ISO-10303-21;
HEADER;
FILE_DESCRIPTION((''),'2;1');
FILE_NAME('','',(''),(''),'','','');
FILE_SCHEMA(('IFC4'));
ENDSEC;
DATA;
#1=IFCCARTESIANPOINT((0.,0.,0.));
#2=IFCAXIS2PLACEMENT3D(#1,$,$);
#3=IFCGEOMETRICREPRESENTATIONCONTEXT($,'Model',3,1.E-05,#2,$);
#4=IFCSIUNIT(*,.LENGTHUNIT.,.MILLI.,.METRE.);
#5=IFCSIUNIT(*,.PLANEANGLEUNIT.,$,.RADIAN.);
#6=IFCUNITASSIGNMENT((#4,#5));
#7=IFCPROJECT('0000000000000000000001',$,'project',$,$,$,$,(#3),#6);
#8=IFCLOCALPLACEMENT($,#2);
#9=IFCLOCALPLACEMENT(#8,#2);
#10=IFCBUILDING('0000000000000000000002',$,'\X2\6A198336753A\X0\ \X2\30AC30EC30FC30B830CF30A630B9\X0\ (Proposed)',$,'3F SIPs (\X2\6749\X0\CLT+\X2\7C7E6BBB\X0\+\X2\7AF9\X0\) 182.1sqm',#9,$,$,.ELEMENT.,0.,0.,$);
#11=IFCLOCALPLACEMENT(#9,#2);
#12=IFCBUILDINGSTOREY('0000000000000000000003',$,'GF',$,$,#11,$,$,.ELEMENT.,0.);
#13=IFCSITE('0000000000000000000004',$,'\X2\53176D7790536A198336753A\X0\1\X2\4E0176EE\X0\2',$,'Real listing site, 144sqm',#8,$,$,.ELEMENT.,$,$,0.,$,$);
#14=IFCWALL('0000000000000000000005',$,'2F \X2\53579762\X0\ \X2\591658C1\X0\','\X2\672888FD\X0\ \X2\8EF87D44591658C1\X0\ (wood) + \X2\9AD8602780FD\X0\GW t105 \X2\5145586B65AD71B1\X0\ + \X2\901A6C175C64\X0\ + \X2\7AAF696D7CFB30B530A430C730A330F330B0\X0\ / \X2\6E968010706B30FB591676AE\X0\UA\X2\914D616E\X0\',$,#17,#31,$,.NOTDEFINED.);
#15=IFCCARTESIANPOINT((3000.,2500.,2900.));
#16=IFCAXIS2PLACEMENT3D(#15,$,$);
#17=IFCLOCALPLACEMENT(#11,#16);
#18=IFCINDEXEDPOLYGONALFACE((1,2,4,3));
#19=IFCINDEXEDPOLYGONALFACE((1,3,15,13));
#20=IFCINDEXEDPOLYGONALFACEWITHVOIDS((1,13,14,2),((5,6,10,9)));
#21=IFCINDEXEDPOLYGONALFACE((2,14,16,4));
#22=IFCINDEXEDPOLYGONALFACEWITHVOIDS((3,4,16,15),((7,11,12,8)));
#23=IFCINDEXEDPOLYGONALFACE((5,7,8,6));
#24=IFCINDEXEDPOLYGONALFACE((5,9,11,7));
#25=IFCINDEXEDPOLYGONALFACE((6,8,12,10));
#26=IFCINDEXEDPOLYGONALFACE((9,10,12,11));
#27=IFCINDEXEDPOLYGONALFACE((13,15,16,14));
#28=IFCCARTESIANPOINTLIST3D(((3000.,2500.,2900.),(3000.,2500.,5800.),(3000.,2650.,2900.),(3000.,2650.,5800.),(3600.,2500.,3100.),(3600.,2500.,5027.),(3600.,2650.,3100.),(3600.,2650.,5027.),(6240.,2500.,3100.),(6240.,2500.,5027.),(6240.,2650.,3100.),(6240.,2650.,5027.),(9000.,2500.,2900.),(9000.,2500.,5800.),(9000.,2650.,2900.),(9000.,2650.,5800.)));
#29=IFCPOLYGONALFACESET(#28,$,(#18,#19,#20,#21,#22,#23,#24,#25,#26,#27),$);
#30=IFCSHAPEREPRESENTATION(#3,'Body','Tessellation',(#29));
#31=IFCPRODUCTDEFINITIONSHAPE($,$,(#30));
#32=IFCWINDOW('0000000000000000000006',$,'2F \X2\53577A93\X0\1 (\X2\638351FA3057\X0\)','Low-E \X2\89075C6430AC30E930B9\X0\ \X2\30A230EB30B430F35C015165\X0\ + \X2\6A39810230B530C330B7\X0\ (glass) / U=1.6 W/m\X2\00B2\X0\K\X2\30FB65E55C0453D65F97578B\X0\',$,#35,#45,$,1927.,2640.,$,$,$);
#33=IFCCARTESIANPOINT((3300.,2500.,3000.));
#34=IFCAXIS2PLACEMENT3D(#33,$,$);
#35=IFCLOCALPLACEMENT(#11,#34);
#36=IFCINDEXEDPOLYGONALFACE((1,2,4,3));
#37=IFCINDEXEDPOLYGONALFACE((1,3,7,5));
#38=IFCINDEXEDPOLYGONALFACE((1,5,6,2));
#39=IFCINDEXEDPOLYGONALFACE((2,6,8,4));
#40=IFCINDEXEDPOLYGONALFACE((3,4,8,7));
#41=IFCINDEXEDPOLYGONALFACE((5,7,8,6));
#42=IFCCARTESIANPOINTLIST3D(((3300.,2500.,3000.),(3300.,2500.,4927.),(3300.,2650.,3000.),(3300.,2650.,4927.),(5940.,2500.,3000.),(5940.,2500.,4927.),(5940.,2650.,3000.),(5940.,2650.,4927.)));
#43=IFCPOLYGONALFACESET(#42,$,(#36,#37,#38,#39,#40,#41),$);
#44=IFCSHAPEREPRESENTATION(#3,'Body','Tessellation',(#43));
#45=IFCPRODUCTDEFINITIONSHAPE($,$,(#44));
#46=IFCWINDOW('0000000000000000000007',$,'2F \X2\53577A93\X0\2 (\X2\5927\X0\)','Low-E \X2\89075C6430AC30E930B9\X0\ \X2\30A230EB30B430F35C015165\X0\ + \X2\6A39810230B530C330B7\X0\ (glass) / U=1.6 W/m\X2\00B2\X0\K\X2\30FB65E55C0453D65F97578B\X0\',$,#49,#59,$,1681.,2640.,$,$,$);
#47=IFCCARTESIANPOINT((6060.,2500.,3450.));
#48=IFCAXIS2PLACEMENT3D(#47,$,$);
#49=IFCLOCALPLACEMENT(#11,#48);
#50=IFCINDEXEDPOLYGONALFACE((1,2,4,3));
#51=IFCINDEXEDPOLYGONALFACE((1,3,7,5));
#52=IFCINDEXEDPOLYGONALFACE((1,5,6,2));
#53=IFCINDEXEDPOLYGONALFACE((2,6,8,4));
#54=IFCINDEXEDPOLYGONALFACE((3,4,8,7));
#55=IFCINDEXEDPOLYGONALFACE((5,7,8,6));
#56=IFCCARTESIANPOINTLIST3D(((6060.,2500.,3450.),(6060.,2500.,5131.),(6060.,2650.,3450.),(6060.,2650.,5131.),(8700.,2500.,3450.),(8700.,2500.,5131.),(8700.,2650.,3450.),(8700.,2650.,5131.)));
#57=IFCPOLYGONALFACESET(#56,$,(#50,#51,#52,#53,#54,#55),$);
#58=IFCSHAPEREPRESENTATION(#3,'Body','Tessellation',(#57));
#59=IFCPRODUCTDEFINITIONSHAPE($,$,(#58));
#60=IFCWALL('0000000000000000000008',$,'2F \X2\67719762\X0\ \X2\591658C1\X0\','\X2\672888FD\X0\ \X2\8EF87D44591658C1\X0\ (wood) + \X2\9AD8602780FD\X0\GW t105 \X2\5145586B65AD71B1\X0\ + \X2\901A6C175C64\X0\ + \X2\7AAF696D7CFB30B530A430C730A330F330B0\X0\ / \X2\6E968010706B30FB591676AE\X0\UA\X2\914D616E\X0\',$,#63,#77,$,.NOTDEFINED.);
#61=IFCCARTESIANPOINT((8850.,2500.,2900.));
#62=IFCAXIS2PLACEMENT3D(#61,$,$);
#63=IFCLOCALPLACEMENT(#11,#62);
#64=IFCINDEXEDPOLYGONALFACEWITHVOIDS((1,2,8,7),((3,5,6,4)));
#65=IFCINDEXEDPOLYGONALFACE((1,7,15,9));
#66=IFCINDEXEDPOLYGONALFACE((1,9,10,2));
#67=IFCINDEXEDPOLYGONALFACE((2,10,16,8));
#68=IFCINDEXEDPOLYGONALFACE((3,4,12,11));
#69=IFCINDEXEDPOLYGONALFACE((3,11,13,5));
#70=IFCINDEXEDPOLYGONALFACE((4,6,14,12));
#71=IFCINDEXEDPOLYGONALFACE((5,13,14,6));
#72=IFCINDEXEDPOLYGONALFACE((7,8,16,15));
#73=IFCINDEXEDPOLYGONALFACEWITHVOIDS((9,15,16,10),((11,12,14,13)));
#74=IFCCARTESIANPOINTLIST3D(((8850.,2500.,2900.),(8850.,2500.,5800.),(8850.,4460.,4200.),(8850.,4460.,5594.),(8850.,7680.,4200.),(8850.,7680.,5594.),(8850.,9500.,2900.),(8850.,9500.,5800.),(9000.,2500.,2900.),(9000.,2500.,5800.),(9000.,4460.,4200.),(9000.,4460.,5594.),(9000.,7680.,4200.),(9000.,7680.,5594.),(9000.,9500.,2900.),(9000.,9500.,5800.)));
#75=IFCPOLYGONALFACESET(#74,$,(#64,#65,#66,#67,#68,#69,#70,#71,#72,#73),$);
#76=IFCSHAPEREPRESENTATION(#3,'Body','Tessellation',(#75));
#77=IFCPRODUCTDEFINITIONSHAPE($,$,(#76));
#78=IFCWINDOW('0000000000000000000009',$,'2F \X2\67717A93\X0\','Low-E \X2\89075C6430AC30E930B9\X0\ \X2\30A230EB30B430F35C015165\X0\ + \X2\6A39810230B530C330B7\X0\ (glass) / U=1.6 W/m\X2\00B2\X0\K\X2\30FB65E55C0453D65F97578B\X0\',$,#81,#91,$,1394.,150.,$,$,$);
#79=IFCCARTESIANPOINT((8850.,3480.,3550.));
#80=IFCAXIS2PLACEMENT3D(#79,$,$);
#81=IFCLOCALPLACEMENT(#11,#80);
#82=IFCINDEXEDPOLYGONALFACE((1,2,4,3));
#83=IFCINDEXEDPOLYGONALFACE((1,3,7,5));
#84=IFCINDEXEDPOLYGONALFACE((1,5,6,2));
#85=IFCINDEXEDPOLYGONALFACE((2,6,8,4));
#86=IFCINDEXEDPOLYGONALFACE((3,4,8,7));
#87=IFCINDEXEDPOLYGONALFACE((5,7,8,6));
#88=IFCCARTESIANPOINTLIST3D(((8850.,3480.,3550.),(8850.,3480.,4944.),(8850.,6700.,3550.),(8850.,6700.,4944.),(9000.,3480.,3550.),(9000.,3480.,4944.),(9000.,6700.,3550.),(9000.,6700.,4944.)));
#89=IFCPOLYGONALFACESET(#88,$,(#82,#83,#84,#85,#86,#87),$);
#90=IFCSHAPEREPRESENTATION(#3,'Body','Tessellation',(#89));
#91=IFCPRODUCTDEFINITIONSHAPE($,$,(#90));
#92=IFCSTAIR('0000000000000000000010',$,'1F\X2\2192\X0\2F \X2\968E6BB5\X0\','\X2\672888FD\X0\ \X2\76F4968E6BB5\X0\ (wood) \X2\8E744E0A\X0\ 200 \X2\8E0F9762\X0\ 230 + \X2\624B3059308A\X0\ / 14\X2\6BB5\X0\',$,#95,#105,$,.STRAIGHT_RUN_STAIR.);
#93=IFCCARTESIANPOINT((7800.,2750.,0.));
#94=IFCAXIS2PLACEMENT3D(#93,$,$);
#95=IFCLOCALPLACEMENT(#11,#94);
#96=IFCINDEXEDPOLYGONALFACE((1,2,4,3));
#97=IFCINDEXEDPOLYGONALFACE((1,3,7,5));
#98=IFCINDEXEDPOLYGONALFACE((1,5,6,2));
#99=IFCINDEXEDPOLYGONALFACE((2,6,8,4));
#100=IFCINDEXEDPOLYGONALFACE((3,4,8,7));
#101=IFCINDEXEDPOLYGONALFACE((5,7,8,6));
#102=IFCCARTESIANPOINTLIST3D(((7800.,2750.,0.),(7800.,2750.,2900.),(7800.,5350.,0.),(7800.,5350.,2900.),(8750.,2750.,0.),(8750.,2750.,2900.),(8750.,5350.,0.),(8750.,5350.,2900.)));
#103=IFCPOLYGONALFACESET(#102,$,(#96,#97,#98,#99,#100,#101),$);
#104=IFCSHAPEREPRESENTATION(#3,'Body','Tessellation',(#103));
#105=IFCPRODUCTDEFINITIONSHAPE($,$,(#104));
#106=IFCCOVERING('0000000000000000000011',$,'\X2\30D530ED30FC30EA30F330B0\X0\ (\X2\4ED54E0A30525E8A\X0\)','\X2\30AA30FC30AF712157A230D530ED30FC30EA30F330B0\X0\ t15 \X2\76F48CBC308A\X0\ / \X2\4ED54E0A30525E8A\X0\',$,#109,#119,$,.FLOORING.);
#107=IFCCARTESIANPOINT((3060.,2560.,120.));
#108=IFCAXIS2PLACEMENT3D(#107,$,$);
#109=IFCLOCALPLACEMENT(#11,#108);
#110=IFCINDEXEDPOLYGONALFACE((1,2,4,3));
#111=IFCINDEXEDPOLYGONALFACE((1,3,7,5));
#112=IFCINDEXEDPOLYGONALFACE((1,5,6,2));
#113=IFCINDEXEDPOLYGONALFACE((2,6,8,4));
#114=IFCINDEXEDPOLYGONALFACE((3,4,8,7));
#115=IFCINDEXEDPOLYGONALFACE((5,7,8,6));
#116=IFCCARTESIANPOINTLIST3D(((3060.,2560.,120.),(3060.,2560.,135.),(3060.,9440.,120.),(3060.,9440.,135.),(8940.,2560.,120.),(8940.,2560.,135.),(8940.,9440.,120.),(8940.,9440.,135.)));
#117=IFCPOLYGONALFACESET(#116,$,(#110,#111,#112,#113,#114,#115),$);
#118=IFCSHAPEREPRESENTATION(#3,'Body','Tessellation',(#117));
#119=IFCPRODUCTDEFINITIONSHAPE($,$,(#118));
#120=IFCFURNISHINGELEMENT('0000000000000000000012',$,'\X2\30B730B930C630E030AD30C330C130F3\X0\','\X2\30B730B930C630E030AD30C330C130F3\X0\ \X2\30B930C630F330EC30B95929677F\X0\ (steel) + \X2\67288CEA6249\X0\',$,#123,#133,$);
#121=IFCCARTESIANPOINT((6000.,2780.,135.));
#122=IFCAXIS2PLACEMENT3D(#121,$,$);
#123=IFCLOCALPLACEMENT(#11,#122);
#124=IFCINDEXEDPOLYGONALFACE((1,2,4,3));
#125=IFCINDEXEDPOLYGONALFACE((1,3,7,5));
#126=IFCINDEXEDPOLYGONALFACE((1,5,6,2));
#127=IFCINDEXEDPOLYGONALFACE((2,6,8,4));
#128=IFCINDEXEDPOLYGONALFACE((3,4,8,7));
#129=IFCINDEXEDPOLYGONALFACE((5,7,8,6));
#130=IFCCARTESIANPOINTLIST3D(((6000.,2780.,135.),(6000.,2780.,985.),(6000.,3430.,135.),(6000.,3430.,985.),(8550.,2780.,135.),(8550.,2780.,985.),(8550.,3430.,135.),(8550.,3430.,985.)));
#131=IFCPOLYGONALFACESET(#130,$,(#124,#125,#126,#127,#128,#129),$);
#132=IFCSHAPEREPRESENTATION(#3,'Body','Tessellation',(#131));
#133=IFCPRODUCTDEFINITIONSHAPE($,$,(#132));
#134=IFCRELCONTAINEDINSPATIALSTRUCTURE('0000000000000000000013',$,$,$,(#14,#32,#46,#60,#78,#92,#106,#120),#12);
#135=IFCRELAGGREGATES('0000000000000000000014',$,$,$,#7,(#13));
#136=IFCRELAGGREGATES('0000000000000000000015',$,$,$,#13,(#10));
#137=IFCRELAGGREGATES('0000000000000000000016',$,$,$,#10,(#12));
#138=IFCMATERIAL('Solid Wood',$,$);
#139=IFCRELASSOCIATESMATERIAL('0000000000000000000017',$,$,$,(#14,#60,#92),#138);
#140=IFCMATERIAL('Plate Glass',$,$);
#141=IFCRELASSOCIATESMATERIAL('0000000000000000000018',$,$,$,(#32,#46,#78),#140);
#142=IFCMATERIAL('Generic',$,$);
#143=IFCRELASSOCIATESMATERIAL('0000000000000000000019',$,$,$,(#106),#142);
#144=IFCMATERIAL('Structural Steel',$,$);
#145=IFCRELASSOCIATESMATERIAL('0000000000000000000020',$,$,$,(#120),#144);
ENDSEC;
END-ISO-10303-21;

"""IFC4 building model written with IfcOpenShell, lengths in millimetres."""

from ifc_helpers import new_model, si_unit, frame, frame_2d, origin, place, context, project, spatial, rectangle, extrude, material, element, fill, save


model = new_model("IFC4")

# Units and contexts
model_context = context("Model", 3, precision=1e-05, world=origin())
ifc_project = project(units=[si_unit("LENGTHUNIT", "METRE", prefix="MILLI"), si_unit("PLANEANGLEUNIT", "RADIAN")], contexts=[model_context])

# Site, building, storey
site_placement = place(None, origin())
site = spatial("IfcSite", under=ifc_project, at=site_placement, Name="北海道標茶町1丁目2", ObjectType="Real listing site, 144sqm", CompositionType="ELEMENT", RefElevation=0.0)
building_placement = place(site_placement, origin())
building = spatial("IfcBuilding", under=site, at=building_placement, Name="標茶町 ガレージハウス (Proposed)", ObjectType="3F SIPs (杉CLT+籾殻+竹) 182.1sqm", CompositionType="ELEMENT", ElevationOfRefHeight=0.0, ElevationOfTerrain=0.0)
storey_placement = place(building_placement, origin())
storey = spatial("IfcBuildingStorey", under=building, at=storey_placement, Name="GF", CompositionType="ELEMENT", Elevation=0.0)

# Shared definitions
ifc_material_1 = material(Name="Solid Wood")

# Shared definitions
ifc_material_2 = material(Name="Plate Glass")

# Wall, openings, windows
wall_1_placement = place(storey_placement, frame((3000.0, 2500.0, 2900.0)))
wall_1 = element("IfcWall", 1, at=wall_1_placement, inside=storey, material=ifc_material_1, Name="2F 南面 外壁", Description="木製 軸組外壁 (wood) + 高性能GW t105 充填断熱 + 通気層 + 窯業系サイディング / 準耐火・外皮UA配慮", PredefinedType="NOTDEFINED", context=model_context, shape_type="SweptSolid", body=[
    extrude(rectangle(XDim=6000.0, YDim=150.0, at=frame_2d((3000.0, 75.0))), frame((3000.0, 2500.0, 2900.0)), (0.0, 0.0, 1.0), 2900.0),
])
opening_1_placement = place(storey_placement, frame((3300.0, 2500.0, 3000.0)))
opening_1 = element("IfcOpeningElement", 2, at=opening_1_placement, cuts=wall_1, PredefinedType="NOTDEFINED", context=model_context, shape_type="SweptSolid", body=[
    extrude(rectangle(XDim=2640.0, YDim=150.0, at=frame_2d((1320.0, 75.0))), frame((3300.0, 2500.0, 3000.0)), (0.0, 0.0, 1.0), 1927.0),
])
opening_2_placement = place(storey_placement, frame((6060.0, 2500.0, 3450.0)))
opening_2 = element("IfcOpeningElement", 3, at=opening_2_placement, cuts=wall_1, PredefinedType="NOTDEFINED", context=model_context, shape_type="SweptSolid", body=[
    extrude(rectangle(XDim=2640.0, YDim=150.0, at=frame_2d((1320.0, 75.0))), frame((6060.0, 2500.0, 3450.0)), (0.0, 0.0, 1.0), 1681.0),
])
window_1_placement = place(storey_placement, frame((3300.0, 2500.0, 3000.0)))
window_1 = element("IfcWindow", 4, at=window_1_placement, inside=storey, material=ifc_material_2, Name="2F 南窓1 (掃出し)", Description="Low-E 複層ガラス アルゴン封入 + 樹脂サッシ (glass) / U=1.6 W/m²K・日射取得型", OverallHeight=1927.0, OverallWidth=2640.0, context=model_context, shape_type="SweptSolid", body=[
    extrude(rectangle(XDim=2640.0, YDim=150.0, at=frame_2d((1320.0, 75.0))), frame((3300.0, 2500.0, 3000.0)), (0.0, 0.0, 1.0), 1927.0),
])
fill(opening_1, window_1)
window_2_placement = place(storey_placement, frame((6060.0, 2500.0, 3450.0)))
window_2 = element("IfcWindow", 5, at=window_2_placement, inside=storey, material=ifc_material_2, Name="2F 南窓2 (大)", Description="Low-E 複層ガラス アルゴン封入 + 樹脂サッシ (glass) / U=1.6 W/m²K・日射取得型", OverallHeight=1681.0, OverallWidth=2640.0, context=model_context, shape_type="SweptSolid", body=[
    extrude(rectangle(XDim=2640.0, YDim=150.0, at=frame_2d((1320.0, 75.0))), frame((6060.0, 2500.0, 3450.0)), (0.0, 0.0, 1.0), 1681.0),
])
fill(opening_2, window_2)

# Wall, opening, window
wall_2_placement = place(storey_placement, frame((8850.0, 2500.0, 2900.0)))
wall_2 = element("IfcWall", 6, at=wall_2_placement, inside=storey, material=ifc_material_1, Name="2F 東面 外壁", Description="木製 軸組外壁 (wood) + 高性能GW t105 充填断熱 + 通気層 + 窯業系サイディング / 準耐火・外皮UA配慮", PredefinedType="NOTDEFINED", context=model_context, shape_type="SweptSolid", body=[
    extrude(rectangle(XDim=150.0, YDim=7000.0, at=frame_2d((75.0, 3500.0))), frame((8850.0, 2500.0, 2900.0)), (0.0, 0.0, 1.0), 2900.0),
])
opening_3_placement = place(storey_placement, frame((8850.0, 3480.0, 3550.0)))
opening_3 = element("IfcOpeningElement", 7, at=opening_3_placement, cuts=wall_2, PredefinedType="NOTDEFINED", context=model_context, shape_type="SweptSolid", body=[
    extrude(rectangle(XDim=150.0, YDim=3220.0, at=frame_2d((75.0, 1610.0))), frame((8850.0, 3480.0, 3550.0)), (0.0, 0.0, 1.0), 1394.0),
])
window_3_placement = place(storey_placement, frame((8850.0, 3480.0, 3550.0)))
window_3 = element("IfcWindow", 8, at=window_3_placement, inside=storey, material=ifc_material_2, Name="2F 東窓", Description="Low-E 複層ガラス アルゴン封入 + 樹脂サッシ (glass) / U=1.6 W/m²K・日射取得型", OverallHeight=1394.0, OverallWidth=150.0, context=model_context, shape_type="SweptSolid", body=[
    extrude(rectangle(XDim=150.0, YDim=3220.0, at=frame_2d((75.0, 1610.0))), frame((8850.0, 3480.0, 3550.0)), (0.0, 0.0, 1.0), 1394.0),
])
fill(opening_3, window_3)

# Stair
stair_placement = place(storey_placement, frame((7800.0, 2750.0, 0.0)))
element("IfcStair", 9, at=stair_placement, inside=storey, material=ifc_material_1, Name="1F→2F 階段", Description="木製 直階段 (wood) 蹴上 200 踏面 230 + 手すり / 14段", PredefinedType="STRAIGHT_RUN_STAIR", context=model_context, shape_type="SweptSolid", body=[
    extrude(rectangle(XDim=950.0, YDim=2600.0, at=frame_2d((475.0, 1300.0))), frame((7800.0, 2750.0, 0.0)), (0.0, 0.0, 1.0), 2900.0),
])

# Covering
ifc_material_3 = material(Name="Generic")
covering_placement = place(storey_placement, frame((3060.0, 2560.0, 120.0)))
element("IfcCovering", 10, at=covering_placement, inside=storey, material=ifc_material_3, Name="フローリング (仕上げ床)", Description="オーク無垢フローリング t15 直貼り / 仕上げ床", PredefinedType="FLOORING", context=model_context, shape_type="SweptSolid", body=[
    extrude(rectangle(XDim=5880.0, YDim=6880.0, at=frame_2d((2940.0, 3440.0))), frame((3060.0, 2560.0, 120.0)), (0.0, 0.0, 1.0), 15.0),
])

# Furnishing element
ifc_material_4 = material(Name="Structural Steel")
furnishing_placement = place(storey_placement, frame((6000.0, 2780.0, 135.0)))
element("IfcFurnishingElement", 11, at=furnishing_placement, inside=storey, material=ifc_material_4, Name="システムキッチン", Description="システムキッチン ステンレス天板 (steel) + 木質扉", context=model_context, shape_type="SweptSolid", body=[
    extrude(rectangle(XDim=2550.0, YDim=650.0, at=frame_2d((1275.0, 325.0))), frame((6000.0, 2780.0, 135.0)), (0.0, 0.0, 1.0), 850.0),
])

save(model, "model.ifc")
